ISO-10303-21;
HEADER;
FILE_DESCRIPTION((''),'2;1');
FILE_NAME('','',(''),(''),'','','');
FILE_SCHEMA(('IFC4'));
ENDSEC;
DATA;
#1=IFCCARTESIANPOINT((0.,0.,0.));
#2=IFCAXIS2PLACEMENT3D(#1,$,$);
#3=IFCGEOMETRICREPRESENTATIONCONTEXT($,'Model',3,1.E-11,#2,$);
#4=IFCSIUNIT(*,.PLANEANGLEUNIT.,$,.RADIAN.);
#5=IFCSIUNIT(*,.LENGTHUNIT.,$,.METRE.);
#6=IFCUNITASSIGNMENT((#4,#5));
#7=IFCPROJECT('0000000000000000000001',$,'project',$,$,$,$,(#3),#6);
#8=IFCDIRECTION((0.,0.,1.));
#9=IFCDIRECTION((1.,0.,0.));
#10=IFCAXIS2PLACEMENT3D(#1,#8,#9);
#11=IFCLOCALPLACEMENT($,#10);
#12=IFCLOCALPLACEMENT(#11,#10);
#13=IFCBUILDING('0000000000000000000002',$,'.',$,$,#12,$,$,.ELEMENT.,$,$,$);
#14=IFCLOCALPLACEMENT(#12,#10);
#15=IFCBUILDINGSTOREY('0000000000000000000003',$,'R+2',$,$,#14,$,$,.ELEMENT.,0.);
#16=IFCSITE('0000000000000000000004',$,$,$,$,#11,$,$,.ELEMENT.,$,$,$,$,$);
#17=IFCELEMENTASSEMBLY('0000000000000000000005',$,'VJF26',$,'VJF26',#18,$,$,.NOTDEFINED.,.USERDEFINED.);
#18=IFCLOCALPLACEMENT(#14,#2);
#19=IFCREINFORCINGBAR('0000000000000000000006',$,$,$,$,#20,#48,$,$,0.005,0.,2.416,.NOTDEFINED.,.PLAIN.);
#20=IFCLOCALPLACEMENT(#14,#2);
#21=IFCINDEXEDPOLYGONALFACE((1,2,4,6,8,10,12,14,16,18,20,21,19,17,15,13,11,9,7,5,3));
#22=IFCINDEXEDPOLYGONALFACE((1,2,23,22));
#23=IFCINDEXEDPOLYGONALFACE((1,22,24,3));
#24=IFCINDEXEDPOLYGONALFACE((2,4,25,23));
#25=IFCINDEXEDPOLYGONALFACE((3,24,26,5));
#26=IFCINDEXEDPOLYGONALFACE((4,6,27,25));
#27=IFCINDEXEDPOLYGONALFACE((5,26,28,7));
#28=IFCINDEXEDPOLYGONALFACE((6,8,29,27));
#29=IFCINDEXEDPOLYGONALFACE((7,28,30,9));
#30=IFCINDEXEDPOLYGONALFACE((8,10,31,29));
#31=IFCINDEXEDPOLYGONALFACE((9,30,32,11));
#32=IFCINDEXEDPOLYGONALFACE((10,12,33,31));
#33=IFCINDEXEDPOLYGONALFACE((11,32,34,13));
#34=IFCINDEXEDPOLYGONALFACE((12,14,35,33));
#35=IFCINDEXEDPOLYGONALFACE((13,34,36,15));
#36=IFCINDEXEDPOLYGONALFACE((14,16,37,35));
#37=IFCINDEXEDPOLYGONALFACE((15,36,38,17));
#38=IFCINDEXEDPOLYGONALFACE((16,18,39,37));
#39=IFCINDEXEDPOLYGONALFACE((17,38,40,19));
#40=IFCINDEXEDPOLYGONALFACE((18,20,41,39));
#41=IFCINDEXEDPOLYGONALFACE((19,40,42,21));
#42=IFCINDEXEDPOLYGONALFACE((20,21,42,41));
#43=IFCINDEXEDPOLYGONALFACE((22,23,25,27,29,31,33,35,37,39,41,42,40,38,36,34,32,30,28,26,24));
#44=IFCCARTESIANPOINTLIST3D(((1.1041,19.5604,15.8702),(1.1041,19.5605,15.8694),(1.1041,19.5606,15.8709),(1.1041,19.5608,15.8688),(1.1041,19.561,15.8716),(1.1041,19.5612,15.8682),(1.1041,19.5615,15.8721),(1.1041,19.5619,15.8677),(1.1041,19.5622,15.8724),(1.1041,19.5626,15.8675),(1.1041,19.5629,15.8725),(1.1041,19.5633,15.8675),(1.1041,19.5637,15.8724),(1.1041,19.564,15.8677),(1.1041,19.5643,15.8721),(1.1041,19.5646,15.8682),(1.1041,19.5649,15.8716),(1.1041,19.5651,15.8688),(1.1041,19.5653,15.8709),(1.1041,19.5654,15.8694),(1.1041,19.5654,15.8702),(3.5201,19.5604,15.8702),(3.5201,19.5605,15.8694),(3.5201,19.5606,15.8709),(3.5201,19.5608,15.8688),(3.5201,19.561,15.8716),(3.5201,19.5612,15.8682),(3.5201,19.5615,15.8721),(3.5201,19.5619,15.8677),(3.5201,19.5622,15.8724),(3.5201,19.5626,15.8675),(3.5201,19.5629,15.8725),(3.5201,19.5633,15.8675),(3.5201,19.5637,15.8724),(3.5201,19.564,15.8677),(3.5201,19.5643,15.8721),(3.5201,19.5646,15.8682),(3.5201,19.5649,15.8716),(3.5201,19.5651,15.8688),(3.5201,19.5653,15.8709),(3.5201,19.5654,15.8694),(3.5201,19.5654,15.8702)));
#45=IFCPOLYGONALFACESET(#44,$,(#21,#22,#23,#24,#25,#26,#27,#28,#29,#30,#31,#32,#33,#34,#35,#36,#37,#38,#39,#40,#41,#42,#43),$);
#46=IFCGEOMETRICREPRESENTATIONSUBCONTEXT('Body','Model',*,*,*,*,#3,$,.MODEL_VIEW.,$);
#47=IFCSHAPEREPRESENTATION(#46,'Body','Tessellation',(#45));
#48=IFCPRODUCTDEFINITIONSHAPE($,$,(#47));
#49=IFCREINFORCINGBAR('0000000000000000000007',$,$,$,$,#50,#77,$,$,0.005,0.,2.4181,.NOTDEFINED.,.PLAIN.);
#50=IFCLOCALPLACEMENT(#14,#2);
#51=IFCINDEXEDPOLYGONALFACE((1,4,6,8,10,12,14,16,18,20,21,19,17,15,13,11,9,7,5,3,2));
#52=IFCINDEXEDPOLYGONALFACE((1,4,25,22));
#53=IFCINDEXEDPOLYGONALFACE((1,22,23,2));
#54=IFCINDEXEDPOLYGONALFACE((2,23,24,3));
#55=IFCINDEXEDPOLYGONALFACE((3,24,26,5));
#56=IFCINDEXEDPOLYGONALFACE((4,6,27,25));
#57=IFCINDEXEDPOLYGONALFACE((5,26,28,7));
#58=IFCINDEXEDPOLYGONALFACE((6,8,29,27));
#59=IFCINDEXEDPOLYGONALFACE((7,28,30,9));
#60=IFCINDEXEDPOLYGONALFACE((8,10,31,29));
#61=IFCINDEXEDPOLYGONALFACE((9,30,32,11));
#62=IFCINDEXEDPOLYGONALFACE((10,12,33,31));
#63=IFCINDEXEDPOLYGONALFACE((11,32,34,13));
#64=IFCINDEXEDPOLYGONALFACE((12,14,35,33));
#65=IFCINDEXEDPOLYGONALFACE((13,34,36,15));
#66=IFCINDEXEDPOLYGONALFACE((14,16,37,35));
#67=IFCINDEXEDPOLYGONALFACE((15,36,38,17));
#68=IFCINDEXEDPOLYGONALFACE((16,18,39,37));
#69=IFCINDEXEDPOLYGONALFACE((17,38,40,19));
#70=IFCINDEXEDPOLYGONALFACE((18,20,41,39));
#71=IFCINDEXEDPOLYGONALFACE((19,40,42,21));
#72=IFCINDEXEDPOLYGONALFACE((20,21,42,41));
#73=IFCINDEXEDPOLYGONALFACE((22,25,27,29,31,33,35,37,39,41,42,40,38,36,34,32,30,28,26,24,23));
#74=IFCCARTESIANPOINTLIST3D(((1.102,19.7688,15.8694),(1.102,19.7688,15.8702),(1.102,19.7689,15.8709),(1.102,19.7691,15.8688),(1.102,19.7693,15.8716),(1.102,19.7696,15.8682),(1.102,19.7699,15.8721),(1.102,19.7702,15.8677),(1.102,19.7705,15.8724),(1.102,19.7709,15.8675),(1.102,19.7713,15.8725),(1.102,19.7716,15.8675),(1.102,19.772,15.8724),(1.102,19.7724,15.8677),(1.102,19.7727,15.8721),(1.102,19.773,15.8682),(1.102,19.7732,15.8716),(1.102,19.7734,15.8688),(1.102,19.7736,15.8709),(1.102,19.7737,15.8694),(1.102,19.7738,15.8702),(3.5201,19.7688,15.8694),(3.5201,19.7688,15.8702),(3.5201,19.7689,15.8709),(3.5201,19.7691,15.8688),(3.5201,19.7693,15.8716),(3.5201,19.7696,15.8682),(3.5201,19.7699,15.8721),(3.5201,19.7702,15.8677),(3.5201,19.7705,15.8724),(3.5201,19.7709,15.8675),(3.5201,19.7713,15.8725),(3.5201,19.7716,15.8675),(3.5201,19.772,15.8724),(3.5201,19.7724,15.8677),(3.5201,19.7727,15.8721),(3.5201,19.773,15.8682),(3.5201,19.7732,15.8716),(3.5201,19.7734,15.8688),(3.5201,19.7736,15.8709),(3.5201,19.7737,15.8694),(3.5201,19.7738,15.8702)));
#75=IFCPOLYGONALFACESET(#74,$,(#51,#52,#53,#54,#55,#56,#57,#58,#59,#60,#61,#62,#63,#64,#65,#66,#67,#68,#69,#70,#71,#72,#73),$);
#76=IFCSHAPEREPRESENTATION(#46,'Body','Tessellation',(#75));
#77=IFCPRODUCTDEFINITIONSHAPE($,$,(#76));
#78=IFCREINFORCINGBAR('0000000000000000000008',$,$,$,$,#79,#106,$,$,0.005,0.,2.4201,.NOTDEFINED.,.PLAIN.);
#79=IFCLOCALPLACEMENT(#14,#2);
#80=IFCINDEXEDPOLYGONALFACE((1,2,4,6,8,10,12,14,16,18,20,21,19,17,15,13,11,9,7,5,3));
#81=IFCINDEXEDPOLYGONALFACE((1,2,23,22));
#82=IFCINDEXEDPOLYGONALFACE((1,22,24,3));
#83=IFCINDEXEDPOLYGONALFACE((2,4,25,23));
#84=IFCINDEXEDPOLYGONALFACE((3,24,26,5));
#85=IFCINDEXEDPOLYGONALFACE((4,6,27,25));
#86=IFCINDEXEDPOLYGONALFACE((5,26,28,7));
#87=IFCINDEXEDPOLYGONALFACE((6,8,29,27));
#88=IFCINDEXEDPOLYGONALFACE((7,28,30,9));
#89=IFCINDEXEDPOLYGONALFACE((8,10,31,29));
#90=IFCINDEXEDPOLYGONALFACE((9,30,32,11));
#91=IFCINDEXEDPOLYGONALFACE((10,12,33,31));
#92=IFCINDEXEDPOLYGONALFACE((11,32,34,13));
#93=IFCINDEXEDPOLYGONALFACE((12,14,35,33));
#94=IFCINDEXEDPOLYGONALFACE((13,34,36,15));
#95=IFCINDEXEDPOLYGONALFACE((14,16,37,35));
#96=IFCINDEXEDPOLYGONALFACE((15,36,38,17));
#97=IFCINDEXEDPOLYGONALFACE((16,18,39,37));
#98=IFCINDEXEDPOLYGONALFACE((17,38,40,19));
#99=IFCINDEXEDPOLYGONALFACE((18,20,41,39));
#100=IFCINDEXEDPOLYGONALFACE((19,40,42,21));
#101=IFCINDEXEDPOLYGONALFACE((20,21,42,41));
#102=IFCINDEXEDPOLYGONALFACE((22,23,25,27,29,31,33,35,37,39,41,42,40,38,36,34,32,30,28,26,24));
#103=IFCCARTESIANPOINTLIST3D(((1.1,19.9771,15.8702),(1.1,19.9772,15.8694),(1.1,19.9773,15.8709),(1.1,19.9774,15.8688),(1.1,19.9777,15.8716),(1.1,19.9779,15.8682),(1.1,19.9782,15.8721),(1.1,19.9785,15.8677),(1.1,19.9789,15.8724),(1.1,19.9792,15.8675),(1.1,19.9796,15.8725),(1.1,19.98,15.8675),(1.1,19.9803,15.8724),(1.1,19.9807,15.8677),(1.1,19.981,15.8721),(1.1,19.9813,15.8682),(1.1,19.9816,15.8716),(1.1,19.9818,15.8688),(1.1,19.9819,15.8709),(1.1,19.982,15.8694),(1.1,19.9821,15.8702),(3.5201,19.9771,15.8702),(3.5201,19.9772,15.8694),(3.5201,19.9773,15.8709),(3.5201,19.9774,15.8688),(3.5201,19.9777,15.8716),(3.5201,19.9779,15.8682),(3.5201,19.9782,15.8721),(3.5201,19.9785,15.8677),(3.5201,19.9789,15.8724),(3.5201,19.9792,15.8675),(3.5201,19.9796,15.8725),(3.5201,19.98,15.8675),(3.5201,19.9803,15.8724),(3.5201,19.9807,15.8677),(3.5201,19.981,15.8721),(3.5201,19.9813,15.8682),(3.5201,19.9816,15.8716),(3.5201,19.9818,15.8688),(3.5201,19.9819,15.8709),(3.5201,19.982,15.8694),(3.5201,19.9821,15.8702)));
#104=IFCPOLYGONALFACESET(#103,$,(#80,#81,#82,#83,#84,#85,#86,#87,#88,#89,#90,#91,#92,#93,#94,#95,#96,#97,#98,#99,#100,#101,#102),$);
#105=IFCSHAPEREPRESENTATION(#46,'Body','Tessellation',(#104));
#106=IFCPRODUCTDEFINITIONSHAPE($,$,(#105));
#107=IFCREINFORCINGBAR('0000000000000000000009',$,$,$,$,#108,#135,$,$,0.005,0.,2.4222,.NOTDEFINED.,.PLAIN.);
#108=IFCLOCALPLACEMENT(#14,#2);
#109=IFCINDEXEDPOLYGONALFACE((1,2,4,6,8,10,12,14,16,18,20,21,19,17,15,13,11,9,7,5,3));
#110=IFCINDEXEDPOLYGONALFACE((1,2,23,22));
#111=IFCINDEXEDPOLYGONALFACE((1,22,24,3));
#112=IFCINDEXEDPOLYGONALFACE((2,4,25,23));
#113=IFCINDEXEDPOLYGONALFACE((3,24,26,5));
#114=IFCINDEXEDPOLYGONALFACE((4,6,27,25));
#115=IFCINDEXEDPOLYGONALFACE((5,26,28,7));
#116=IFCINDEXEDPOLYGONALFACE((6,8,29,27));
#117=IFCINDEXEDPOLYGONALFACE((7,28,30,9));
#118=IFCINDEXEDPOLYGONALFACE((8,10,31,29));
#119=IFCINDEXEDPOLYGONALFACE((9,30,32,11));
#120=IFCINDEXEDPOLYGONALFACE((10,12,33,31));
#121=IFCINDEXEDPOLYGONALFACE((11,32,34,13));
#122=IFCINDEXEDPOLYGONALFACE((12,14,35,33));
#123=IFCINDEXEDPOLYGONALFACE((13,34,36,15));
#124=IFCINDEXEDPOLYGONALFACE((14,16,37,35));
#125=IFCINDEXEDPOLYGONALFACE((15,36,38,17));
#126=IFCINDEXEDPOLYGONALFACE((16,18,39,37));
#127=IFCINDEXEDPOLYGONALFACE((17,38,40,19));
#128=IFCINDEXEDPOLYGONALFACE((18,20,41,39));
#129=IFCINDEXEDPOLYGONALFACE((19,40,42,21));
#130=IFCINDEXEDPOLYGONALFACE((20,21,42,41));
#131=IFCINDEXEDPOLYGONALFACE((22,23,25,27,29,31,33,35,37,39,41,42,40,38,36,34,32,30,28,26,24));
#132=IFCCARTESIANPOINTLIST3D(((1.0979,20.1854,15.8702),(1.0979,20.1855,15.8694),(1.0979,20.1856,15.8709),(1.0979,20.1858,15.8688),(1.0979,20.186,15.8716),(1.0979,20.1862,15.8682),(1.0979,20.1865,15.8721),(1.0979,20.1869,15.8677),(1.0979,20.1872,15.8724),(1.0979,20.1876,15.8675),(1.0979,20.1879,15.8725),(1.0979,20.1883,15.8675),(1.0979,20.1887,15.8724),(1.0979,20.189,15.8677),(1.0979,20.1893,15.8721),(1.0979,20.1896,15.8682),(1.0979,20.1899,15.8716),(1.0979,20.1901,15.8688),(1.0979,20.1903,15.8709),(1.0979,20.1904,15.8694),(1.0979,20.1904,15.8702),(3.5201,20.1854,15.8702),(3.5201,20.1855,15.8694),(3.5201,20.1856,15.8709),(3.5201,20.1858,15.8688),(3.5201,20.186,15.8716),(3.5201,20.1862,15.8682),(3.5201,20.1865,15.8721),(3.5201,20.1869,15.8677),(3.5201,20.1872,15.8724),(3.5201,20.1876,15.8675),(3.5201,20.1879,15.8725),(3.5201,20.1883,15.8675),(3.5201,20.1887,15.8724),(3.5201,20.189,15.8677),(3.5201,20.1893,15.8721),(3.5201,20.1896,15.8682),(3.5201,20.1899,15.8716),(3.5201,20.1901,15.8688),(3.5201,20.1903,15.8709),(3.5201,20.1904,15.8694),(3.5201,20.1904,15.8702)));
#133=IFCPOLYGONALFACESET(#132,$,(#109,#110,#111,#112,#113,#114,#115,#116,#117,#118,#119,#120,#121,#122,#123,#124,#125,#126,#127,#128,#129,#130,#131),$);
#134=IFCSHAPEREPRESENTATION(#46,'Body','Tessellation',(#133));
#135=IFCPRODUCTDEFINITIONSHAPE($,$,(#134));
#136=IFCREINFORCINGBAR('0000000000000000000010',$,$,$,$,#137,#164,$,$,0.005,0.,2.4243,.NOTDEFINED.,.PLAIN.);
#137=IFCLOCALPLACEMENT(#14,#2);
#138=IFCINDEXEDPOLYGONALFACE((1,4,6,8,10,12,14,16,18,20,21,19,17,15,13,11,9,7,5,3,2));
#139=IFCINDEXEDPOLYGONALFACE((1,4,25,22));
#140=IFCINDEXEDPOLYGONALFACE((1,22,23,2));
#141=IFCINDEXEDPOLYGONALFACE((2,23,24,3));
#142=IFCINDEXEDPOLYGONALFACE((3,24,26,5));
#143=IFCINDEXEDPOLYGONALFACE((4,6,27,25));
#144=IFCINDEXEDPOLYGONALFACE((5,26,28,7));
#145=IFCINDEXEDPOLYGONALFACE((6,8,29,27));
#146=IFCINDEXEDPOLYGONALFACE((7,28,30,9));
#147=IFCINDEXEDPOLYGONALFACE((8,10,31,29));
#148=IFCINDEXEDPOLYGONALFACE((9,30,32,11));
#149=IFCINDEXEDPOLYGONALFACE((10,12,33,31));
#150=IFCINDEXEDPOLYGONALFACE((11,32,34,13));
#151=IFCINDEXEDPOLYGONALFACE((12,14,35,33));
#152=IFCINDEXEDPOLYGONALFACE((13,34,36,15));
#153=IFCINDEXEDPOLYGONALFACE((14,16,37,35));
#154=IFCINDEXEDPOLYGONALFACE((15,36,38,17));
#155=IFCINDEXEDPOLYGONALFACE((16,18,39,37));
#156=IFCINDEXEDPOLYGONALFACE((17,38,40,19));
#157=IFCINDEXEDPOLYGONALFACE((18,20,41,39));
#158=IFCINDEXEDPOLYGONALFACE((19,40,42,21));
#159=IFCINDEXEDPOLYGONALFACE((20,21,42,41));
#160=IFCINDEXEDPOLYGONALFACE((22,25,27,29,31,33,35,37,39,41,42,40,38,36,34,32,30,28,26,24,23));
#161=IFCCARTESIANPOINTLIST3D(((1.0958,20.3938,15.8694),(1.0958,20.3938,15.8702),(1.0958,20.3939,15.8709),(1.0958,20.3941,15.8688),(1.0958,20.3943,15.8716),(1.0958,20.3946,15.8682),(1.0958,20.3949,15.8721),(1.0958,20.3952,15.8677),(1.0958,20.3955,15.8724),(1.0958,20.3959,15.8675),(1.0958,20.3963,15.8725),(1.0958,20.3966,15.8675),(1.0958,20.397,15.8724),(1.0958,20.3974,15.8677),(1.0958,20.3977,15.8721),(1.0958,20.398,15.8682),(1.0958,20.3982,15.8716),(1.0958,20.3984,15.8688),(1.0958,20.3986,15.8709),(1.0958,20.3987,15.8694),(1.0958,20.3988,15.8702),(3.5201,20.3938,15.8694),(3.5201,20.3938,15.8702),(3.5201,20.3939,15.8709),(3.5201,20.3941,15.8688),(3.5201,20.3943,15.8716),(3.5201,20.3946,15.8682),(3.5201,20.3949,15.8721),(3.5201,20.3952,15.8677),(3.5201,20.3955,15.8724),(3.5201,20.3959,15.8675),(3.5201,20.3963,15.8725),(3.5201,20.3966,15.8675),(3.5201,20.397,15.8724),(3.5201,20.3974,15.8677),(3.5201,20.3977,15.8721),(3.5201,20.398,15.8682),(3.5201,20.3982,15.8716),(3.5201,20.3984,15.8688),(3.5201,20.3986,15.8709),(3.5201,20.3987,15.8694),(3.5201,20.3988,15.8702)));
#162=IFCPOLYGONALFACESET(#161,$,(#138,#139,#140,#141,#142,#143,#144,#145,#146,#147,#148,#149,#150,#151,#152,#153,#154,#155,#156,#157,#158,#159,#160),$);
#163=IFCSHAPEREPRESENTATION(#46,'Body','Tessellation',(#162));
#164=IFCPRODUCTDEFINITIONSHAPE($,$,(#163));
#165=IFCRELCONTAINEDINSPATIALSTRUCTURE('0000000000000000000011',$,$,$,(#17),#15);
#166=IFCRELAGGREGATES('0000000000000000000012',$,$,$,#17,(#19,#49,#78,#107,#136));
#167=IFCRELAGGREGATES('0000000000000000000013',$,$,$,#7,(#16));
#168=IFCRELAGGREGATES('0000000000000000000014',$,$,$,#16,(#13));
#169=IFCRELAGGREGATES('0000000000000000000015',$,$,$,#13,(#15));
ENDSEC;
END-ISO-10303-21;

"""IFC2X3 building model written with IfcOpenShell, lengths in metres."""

from ifc_helpers import new_model, entity, si_unit, origin, origin_with_axes, place, context, subcontext, project, spatial, shape, element, aggregate, save


model = new_model("IFC2X3")

# Units and contexts
model_context = context("Model", 3, precision=1e-11, world=origin())
body_context = subcontext(model_context, "Body", "Model", "MODEL_VIEW")
ifc_project = project(units=[si_unit("PLANEANGLEUNIT", "RADIAN"), si_unit("LENGTHUNIT", "METRE")], contexts=[model_context])

# Site, building, storey
site_placement = place(None, origin_with_axes())
site = spatial("IfcSite", under=ifc_project, at=site_placement, CompositionType="ELEMENT")
building_placement = place(site_placement, origin_with_axes())
building = spatial("IfcBuilding", under=site, at=building_placement, Name=".", CompositionType="ELEMENT")
storey_placement = place(building_placement, origin_with_axes())
storey = spatial("IfcBuildingStorey", under=building, at=storey_placement, Name="R+2", CompositionType="ELEMENT", Elevation=0.0)

# Element assembly, reinforcing bars
assembly_1_placement = place(storey_placement, origin_with_axes())
assembly_1 = element("IfcElementAssembly", 1, at=assembly_1_placement, inside=storey, Name="VJF26", ObjectType="VJF26", AssemblyPlace="NOTDEFINED", PredefinedType="USERDEFINED")
reinforcing_bar_1_placement = place(assembly_1_placement, origin_with_axes())
reinforcing_bar_1 = element("IfcReinforcingBar", 2, at=reinforcing_bar_1_placement, BarLength=2.416, BarRole="NOTDEFINED", BarSurface="PLAIN", CrossSectionArea=0.0, NominalDiameter=0.005, shapes=[
    shape(body_context, "Body", "AdvancedSweptSolid", [entity("IfcSweptDiskSolid", entity("IfcPolyline", [entity("IfcCartesianPoint", [1.1041, 19.5629, 15.87]), entity("IfcCartesianPoint", [3.5201, 19.5629, 15.87])]), 0.0025, None, 0.0, 2.416)]),
    shape(body_context, "Body", "AdvancedSweptSolid", [entity("IfcSweptDiskSolid", entity("IfcPolyline", [entity("IfcCartesianPoint", [1.1041, 19.5629, 15.87]), entity("IfcCartesianPoint", [3.5201, 19.5629, 15.87])]), 0.0025, None, 0.0, 2.416)]),
])
reinforcing_bar_2_placement = place(assembly_1_placement, origin_with_axes())
reinforcing_bar_2 = element("IfcReinforcingBar", 3, at=reinforcing_bar_2_placement, BarLength=2.4181, BarRole="NOTDEFINED", BarSurface="PLAIN", CrossSectionArea=0.0, NominalDiameter=0.005, shapes=[
    shape(body_context, "Body", "AdvancedSweptSolid", [entity("IfcSweptDiskSolid", entity("IfcPolyline", [entity("IfcCartesianPoint", [1.102, 19.7713, 15.87]), entity("IfcCartesianPoint", [3.5201, 19.7713, 15.87])]), 0.0025, None, 0.0, 2.4181)]),
    shape(body_context, "Body", "AdvancedSweptSolid", [entity("IfcSweptDiskSolid", entity("IfcPolyline", [entity("IfcCartesianPoint", [1.102, 19.7713, 15.87]), entity("IfcCartesianPoint", [3.5201, 19.7713, 15.87])]), 0.0025, None, 0.0, 2.4181)]),
])
reinforcing_bar_3_placement = place(assembly_1_placement, origin_with_axes())
reinforcing_bar_3 = element("IfcReinforcingBar", 4, at=reinforcing_bar_3_placement, BarLength=2.4201, BarRole="NOTDEFINED", BarSurface="PLAIN", CrossSectionArea=0.0, NominalDiameter=0.005, shapes=[
    shape(body_context, "Body", "AdvancedSweptSolid", [entity("IfcSweptDiskSolid", entity("IfcPolyline", [entity("IfcCartesianPoint", [1.1, 19.9796, 15.87]), entity("IfcCartesianPoint", [3.5201, 19.9796, 15.87])]), 0.0025, None, 0.0, 2.4201)]),
    shape(body_context, "Body", "AdvancedSweptSolid", [entity("IfcSweptDiskSolid", entity("IfcPolyline", [entity("IfcCartesianPoint", [1.1, 19.9796, 15.87]), entity("IfcCartesianPoint", [3.5201, 19.9796, 15.87])]), 0.0025, None, 0.0, 2.4201)]),
])
reinforcing_bar_4_placement = place(assembly_1_placement, origin_with_axes())
reinforcing_bar_4 = element("IfcReinforcingBar", 5, at=reinforcing_bar_4_placement, BarLength=2.4222, BarRole="NOTDEFINED", BarSurface="PLAIN", CrossSectionArea=0.0, NominalDiameter=0.005, shapes=[
    shape(body_context, "Body", "AdvancedSweptSolid", [entity("IfcSweptDiskSolid", entity("IfcPolyline", [entity("IfcCartesianPoint", [1.0979, 20.1879, 15.87]), entity("IfcCartesianPoint", [3.5201, 20.1879, 15.87])]), 0.0025, None, 0.0, 2.4222)]),
    shape(body_context, "Body", "AdvancedSweptSolid", [entity("IfcSweptDiskSolid", entity("IfcPolyline", [entity("IfcCartesianPoint", [1.0979, 20.1879, 15.87]), entity("IfcCartesianPoint", [3.5201, 20.1879, 15.87])]), 0.0025, None, 0.0, 2.4222)]),
])
reinforcing_bar_5_placement = place(assembly_1_placement, origin_with_axes())
reinforcing_bar_5 = element("IfcReinforcingBar", 6, at=reinforcing_bar_5_placement, BarLength=2.4243, BarRole="NOTDEFINED", BarSurface="PLAIN", CrossSectionArea=0.0, NominalDiameter=0.005, shapes=[
    shape(body_context, "Body", "AdvancedSweptSolid", [entity("IfcSweptDiskSolid", entity("IfcPolyline", [entity("IfcCartesianPoint", [1.0958, 20.3963, 15.87]), entity("IfcCartesianPoint", [3.5201, 20.3963, 15.87])]), 0.0025, None, 0.0, 2.4243)]),
    shape(body_context, "Body", "AdvancedSweptSolid", [entity("IfcSweptDiskSolid", entity("IfcPolyline", [entity("IfcCartesianPoint", [1.0958, 20.3963, 15.87]), entity("IfcCartesianPoint", [3.5201, 20.3963, 15.87])]), 0.0025, None, 0.0, 2.4243)]),
])
aggregate(assembly_1, [reinforcing_bar_1, reinforcing_bar_2, reinforcing_bar_3, reinforcing_bar_4, reinforcing_bar_5])

save(model, "model.ifc")
